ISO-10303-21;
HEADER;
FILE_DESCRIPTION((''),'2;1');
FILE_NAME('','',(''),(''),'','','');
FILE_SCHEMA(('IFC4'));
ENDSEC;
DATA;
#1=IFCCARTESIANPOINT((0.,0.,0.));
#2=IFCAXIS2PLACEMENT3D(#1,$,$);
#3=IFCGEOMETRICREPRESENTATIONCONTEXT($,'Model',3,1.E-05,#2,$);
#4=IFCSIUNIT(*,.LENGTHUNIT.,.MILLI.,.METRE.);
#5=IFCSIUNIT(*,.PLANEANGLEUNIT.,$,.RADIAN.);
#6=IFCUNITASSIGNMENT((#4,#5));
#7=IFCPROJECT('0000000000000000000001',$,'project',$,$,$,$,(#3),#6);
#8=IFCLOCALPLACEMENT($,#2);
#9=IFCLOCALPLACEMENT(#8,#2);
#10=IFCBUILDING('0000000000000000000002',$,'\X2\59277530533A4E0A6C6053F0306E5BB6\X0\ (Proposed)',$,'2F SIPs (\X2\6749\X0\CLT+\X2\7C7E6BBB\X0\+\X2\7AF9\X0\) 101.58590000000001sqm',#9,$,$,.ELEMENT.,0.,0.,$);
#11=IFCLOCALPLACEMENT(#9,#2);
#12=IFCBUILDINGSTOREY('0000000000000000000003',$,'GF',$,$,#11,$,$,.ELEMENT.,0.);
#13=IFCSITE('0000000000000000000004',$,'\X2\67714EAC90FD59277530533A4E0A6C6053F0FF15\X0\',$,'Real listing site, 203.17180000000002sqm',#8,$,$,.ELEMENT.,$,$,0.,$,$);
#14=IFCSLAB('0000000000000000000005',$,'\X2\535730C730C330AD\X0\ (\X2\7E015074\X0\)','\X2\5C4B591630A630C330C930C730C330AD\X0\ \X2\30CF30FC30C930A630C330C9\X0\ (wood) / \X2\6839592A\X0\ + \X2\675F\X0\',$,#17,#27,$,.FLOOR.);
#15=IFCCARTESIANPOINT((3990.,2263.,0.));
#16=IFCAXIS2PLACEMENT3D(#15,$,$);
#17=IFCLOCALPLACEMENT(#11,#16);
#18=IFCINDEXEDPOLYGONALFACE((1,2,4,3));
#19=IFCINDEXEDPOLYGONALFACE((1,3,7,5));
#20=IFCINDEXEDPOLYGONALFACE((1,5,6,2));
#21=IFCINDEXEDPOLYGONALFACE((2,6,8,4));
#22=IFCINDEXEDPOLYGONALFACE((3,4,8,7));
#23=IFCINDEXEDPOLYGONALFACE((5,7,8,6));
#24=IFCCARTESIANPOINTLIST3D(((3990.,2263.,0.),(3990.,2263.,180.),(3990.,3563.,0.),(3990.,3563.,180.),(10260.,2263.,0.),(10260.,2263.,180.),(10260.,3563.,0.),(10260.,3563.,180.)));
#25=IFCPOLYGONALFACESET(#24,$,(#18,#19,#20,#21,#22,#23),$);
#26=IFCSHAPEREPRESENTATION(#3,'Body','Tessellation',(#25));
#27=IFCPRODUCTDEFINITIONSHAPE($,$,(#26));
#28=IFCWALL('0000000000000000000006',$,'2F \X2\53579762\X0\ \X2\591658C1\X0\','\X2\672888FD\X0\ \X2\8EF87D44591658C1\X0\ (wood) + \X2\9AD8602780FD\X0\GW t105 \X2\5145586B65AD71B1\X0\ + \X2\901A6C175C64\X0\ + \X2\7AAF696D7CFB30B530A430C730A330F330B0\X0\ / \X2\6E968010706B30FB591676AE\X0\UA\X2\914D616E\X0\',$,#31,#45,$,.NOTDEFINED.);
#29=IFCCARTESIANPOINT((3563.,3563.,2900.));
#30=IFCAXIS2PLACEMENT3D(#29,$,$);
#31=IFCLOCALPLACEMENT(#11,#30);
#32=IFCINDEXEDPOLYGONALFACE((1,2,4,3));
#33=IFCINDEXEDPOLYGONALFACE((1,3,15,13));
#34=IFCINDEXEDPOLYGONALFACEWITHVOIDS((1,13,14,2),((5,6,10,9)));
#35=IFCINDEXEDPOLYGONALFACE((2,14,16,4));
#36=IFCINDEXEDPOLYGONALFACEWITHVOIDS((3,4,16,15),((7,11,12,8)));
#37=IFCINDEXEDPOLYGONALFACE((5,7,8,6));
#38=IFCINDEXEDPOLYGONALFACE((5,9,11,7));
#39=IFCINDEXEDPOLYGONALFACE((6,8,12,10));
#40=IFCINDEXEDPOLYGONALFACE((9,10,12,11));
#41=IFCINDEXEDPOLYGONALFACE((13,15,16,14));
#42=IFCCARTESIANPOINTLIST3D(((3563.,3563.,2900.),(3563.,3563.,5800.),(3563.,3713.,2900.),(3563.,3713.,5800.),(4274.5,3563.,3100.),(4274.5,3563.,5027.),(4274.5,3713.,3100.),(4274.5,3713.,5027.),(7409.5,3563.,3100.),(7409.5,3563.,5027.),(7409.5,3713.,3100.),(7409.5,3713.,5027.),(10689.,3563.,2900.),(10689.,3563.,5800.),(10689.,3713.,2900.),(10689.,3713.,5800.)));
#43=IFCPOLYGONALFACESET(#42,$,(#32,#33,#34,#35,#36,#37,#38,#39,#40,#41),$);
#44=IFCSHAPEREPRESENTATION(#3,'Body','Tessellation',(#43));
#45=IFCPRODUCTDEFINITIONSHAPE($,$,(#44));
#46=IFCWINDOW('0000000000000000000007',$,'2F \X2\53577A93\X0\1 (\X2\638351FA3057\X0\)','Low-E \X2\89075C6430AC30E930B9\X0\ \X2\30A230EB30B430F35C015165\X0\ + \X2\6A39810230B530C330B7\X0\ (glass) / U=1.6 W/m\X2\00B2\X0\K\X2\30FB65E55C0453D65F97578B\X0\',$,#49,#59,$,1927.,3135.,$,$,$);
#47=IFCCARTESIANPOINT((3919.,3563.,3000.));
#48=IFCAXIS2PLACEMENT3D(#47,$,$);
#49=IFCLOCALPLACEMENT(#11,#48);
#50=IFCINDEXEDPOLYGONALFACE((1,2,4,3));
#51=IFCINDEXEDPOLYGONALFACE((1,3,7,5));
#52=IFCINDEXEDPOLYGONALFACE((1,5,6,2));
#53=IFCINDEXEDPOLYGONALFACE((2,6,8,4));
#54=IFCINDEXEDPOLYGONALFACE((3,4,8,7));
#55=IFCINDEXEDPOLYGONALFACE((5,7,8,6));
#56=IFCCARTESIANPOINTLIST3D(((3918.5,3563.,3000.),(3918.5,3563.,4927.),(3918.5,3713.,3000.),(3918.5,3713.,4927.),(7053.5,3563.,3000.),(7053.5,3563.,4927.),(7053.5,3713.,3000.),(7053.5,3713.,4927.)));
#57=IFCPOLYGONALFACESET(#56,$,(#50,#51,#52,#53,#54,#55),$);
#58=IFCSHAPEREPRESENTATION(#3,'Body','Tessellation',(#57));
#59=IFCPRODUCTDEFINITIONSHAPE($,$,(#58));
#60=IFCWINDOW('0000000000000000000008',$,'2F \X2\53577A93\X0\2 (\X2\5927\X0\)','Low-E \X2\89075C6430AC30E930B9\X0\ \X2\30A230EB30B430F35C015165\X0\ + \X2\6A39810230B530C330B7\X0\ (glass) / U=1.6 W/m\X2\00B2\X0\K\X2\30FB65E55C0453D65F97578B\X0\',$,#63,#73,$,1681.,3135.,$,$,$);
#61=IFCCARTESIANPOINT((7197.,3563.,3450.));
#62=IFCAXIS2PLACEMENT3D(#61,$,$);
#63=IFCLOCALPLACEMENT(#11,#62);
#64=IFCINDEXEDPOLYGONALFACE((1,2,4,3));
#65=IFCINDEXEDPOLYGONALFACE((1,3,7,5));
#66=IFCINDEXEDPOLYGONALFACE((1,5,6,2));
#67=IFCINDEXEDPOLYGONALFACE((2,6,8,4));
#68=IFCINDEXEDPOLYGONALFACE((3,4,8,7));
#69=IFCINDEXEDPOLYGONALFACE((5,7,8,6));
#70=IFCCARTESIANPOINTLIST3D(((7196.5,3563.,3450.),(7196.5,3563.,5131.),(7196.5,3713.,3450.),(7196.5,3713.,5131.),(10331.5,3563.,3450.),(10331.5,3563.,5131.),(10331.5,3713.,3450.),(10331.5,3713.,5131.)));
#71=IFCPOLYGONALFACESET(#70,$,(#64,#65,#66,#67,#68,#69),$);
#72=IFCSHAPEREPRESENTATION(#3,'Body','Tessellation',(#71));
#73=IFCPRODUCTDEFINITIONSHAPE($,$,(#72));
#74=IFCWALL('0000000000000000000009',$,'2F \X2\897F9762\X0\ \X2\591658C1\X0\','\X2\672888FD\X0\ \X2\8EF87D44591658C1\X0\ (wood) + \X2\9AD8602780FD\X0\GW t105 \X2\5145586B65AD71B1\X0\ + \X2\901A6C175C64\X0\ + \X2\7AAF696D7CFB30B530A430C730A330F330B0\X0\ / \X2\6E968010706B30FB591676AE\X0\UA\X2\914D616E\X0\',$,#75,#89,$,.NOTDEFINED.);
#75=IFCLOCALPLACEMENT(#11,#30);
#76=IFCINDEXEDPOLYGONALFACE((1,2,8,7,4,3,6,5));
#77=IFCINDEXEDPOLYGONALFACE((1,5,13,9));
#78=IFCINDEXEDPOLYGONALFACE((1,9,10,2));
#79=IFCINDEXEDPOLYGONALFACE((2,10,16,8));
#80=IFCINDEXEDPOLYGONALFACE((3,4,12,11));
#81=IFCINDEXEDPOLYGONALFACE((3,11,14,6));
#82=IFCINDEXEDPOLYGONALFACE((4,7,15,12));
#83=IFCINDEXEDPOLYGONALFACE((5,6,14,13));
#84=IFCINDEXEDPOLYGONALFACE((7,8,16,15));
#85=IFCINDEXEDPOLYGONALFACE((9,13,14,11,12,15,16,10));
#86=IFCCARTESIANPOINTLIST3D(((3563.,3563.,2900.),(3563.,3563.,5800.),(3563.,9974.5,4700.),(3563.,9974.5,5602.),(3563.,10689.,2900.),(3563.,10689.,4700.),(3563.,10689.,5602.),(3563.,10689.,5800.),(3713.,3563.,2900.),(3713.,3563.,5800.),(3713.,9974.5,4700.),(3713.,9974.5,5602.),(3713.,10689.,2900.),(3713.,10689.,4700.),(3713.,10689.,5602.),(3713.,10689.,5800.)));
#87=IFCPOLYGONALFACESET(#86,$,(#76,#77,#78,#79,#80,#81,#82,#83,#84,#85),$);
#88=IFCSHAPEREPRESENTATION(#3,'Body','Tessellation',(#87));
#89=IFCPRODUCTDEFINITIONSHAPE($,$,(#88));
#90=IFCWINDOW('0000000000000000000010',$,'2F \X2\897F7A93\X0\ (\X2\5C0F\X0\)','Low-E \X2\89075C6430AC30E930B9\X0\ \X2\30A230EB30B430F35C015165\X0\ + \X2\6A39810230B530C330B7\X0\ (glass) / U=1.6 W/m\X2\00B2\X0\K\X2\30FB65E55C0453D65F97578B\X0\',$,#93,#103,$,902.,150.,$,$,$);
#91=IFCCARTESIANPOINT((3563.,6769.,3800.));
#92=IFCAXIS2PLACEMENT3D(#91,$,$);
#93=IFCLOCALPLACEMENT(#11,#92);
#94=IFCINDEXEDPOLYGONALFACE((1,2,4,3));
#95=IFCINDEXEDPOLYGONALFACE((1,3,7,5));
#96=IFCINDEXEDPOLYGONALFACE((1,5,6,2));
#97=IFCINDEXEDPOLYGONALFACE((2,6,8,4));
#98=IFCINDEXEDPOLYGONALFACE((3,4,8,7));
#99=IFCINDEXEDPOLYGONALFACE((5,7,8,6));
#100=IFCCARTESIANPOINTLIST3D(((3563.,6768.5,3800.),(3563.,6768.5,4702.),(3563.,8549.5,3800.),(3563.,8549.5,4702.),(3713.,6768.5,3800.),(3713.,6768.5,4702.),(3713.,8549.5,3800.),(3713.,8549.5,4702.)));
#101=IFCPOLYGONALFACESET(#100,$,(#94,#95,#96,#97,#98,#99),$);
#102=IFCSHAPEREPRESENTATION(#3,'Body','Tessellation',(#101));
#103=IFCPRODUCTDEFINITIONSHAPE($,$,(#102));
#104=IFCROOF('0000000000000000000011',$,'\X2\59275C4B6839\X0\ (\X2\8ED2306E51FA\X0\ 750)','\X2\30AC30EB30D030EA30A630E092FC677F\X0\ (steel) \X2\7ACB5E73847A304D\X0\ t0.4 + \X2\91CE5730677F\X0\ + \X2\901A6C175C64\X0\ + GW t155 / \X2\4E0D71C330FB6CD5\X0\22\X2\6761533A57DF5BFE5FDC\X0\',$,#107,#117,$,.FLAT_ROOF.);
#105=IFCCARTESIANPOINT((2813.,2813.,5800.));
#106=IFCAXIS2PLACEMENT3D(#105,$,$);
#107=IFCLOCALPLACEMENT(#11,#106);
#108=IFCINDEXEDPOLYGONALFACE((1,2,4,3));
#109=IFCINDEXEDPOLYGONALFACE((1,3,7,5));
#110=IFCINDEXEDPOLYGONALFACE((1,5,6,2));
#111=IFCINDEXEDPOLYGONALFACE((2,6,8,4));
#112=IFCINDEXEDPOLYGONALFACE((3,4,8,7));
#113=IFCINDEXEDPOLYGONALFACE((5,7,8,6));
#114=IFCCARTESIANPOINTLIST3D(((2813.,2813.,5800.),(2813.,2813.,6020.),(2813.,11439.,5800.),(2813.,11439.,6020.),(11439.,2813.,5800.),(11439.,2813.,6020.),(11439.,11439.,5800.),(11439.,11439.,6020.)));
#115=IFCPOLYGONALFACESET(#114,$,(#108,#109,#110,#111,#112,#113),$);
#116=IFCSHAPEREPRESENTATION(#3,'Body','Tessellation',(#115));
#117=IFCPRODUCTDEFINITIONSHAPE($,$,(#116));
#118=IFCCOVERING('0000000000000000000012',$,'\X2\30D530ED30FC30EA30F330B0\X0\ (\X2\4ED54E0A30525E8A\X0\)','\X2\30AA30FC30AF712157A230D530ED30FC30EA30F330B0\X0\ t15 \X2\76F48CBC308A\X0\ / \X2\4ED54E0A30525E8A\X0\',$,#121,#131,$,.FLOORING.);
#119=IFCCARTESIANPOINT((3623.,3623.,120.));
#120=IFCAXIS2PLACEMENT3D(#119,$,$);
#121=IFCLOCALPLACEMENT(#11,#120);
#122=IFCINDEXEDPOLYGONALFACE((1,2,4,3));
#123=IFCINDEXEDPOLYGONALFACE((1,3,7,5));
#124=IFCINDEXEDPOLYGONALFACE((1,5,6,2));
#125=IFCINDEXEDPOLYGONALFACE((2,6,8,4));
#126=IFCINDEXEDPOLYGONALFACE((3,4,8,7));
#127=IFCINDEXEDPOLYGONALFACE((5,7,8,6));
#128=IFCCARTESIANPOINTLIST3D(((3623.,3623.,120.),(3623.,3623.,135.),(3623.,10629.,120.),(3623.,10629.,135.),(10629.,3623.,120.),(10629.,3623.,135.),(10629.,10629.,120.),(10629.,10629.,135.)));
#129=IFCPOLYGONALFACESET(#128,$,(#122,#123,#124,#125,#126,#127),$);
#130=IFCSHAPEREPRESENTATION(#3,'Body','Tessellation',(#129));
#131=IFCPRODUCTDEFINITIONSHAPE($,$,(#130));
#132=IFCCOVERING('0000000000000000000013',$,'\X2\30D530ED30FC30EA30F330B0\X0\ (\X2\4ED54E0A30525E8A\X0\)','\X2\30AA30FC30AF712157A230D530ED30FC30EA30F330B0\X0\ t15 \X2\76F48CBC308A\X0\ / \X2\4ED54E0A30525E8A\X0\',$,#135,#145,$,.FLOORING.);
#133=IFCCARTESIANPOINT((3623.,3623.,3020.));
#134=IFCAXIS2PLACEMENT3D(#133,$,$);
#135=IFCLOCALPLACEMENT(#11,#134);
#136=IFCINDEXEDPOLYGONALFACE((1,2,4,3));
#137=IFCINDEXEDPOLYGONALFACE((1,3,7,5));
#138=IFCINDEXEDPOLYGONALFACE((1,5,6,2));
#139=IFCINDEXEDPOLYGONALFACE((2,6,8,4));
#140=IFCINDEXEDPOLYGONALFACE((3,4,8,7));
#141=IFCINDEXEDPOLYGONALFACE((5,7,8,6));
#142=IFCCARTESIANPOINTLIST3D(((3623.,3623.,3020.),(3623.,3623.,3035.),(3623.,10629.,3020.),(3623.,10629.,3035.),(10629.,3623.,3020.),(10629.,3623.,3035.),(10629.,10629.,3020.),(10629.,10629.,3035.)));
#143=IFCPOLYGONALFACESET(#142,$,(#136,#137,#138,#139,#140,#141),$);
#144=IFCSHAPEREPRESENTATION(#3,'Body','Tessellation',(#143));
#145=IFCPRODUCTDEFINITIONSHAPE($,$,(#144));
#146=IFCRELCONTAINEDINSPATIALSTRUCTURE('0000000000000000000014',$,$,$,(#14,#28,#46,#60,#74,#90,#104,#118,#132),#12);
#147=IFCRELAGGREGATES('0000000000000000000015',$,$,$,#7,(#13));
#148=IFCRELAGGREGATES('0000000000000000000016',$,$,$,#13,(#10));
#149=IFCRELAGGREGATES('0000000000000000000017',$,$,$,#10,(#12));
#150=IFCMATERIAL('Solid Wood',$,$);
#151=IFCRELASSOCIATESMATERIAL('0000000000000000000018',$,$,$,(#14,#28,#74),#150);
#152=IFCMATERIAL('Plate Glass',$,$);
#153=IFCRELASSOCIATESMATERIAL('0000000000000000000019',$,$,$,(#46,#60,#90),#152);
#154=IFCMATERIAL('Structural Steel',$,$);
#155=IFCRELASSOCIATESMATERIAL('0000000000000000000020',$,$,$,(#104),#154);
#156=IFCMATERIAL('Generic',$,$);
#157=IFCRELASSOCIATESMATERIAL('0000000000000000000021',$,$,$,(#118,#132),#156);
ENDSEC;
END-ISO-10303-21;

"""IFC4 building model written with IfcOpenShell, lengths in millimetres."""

from ifc_helpers import new_model, si_unit, frame, frame_2d, origin, place, context, project, spatial, rectangle, extrude, material, element, fill, save


model = new_model("IFC4")

# Units and contexts
model_context = context("Model", 3, precision=1e-05, world=origin())
ifc_project = project(units=[si_unit("LENGTHUNIT", "METRE", prefix="MILLI"), si_unit("PLANEANGLEUNIT", "RADIAN")], contexts=[model_context])

# Site, building, storey
site_placement = place(None, origin())
site = spatial("IfcSite", under=ifc_project, at=site_placement, Name="東京都大田区上池台５", ObjectType="Real listing site, 203.17180000000002sqm", CompositionType="ELEMENT", RefElevation=0.0)
building_placement = place(site_placement, origin())
building = spatial("IfcBuilding", under=site, at=building_placement, Name="大田区上池台の家 (Proposed)", ObjectType="2F SIPs (杉CLT+籾殻+竹) 101.58590000000001sqm", CompositionType="ELEMENT", ElevationOfRefHeight=0.0, ElevationOfTerrain=0.0)
storey_placement = place(building_placement, origin())
storey = spatial("IfcBuildingStorey", under=building, at=storey_placement, Name="GF", CompositionType="ELEMENT", Elevation=0.0)

# Slab
ifc_material_1 = material(Name="Solid Wood")
slab_1_placement = place(storey_placement, frame((3990.0, 2263.0, 0.0)))
element("IfcSlab", 1, at=slab_1_placement, inside=storey, material=ifc_material_1, Name="南デッキ (縁側)", Description="屋外ウッドデッキ ハードウッド (wood) / 根太 + 束", PredefinedType="FLOOR", context=model_context, shape_type="SweptSolid", body=[
    extrude(rectangle(XDim=6270.0, YDim=1300.0, at=frame_2d((3135.0, 650.0))), frame((3990.0, 2263.0, 0.0)), (0.0, 0.0, 1.0), 180.0),
])

# Shared definitions
ifc_material_2 = material(Name="Plate Glass")

# Wall, openings, windows
wall_1_placement = place(storey_placement, frame((3563.0, 3563.0, 2900.0)))
wall_1 = element("IfcWall", 2, at=wall_1_placement, inside=storey, material=ifc_material_1, Name="2F 南面 外壁", Description="木製 軸組外壁 (wood) + 高性能GW t105 充填断熱 + 通気層 + 窯業系サイディング / 準耐火・外皮UA配慮", PredefinedType="NOTDEFINED", context=model_context, shape_type="SweptSolid", body=[
    extrude(rectangle(XDim=7126.0, YDim=150.0, at=frame_2d((3563.0, 75.0))), frame((3563.0, 3563.0, 2900.0)), (0.0, 0.0, 1.0), 2900.0),
])
opening_1_placement = place(storey_placement, frame((3919.0, 3563.0, 3000.0)))
opening_1 = element("IfcOpeningElement", 3, at=opening_1_placement, cuts=wall_1, PredefinedType="NOTDEFINED", context=model_context, shape_type="SweptSolid", body=[
    extrude(rectangle(XDim=3135.0, YDim=150.0, at=frame_2d((1567.0, 75.0))), frame((3919.0, 3563.0, 3000.0)), (0.0, 0.0, 1.0), 1927.0),
])
opening_2_placement = place(storey_placement, frame((7197.0, 3563.0, 3450.0)))
opening_2 = element("IfcOpeningElement", 4, at=opening_2_placement, cuts=wall_1, PredefinedType="NOTDEFINED", context=model_context, shape_type="SweptSolid", body=[
    extrude(rectangle(XDim=3135.0, YDim=150.0, at=frame_2d((1567.0, 75.0))), frame((7197.0, 3563.0, 3450.0)), (0.0, 0.0, 1.0), 1681.0),
])
window_1_placement = place(storey_placement, frame((3919.0, 3563.0, 3000.0)))
window_1 = element("IfcWindow", 5, at=window_1_placement, inside=storey, material=ifc_material_2, Name="2F 南窓1 (掃出し)", Description="Low-E 複層ガラス アルゴン封入 + 樹脂サッシ (glass) / U=1.6 W/m²K・日射取得型", OverallHeight=1927.0, OverallWidth=3135.0, context=model_context, shape_type="SweptSolid", body=[
    extrude(rectangle(XDim=3135.0, YDim=150.0, at=frame_2d((1567.0, 75.0))), frame((3919.0, 3563.0, 3000.0)), (0.0, 0.0, 1.0), 1927.0),
])
fill(opening_1, window_1)
window_2_placement = place(storey_placement, frame((7197.0, 3563.0, 3450.0)))
window_2 = element("IfcWindow", 6, at=window_2_placement, inside=storey, material=ifc_material_2, Name="2F 南窓2 (大)", Description="Low-E 複層ガラス アルゴン封入 + 樹脂サッシ (glass) / U=1.6 W/m²K・日射取得型", OverallHeight=1681.0, OverallWidth=3135.0, context=model_context, shape_type="SweptSolid", body=[
    extrude(rectangle(XDim=3135.0, YDim=150.0, at=frame_2d((1567.0, 75.0))), frame((7197.0, 3563.0, 3450.0)), (0.0, 0.0, 1.0), 1681.0),
])
fill(opening_2, window_2)

# Wall, opening, window
wall_2_placement = place(storey_placement, frame((3563.0, 3563.0, 2900.0)))
wall_2 = element("IfcWall", 7, at=wall_2_placement, inside=storey, material=ifc_material_1, Name="2F 西面 外壁", Description="木製 軸組外壁 (wood) + 高性能GW t105 充填断熱 + 通気層 + 窯業系サイディング / 準耐火・外皮UA配慮", PredefinedType="NOTDEFINED", context=model_context, shape_type="SweptSolid", body=[
    extrude(rectangle(XDim=150.0, YDim=7126.0, at=frame_2d((75.0, 3563.0))), frame((3563.0, 3563.0, 2900.0)), (0.0, 0.0, 1.0), 2900.0),
])
opening_3_placement = place(storey_placement, frame((3563.0, 6769.0, 3800.0)))
opening_3 = element("IfcOpeningElement", 8, at=opening_3_placement, cuts=wall_2, PredefinedType="NOTDEFINED", context=model_context, shape_type="SweptSolid", body=[
    extrude(rectangle(XDim=150.0, YDim=1781.0, at=frame_2d((75.0, 890.0))), frame((3563.0, 6769.0, 3800.0)), (0.0, 0.0, 1.0), 902.0),
])
window_3_placement = place(storey_placement, frame((3563.0, 6769.0, 3800.0)))
window_3 = element("IfcWindow", 9, at=window_3_placement, inside=storey, material=ifc_material_2, Name="2F 西窓 (小)", Description="Low-E 複層ガラス アルゴン封入 + 樹脂サッシ (glass) / U=1.6 W/m²K・日射取得型", OverallHeight=902.0, OverallWidth=150.0, context=model_context, shape_type="SweptSolid", body=[
    extrude(rectangle(XDim=150.0, YDim=1781.0, at=frame_2d((75.0, 890.0))), frame((3563.0, 6769.0, 3800.0)), (0.0, 0.0, 1.0), 902.0),
])
fill(opening_3, window_3)

# Roof
ifc_material_3 = material(Name="Structural Steel")
roof_placement = place(storey_placement, frame((2813.0, 2813.0, 5800.0)))
element("IfcRoof", 10, at=roof_placement, inside=storey, material=ifc_material_3, Name="大屋根 (軒の出 750)", Description="ガルバリウム鋼板 (steel) 立平葺き t0.4 + 野地板 + 通気層 + GW t155 / 不燃・法22条区域対応", PredefinedType="FLAT_ROOF", context=model_context, shape_type="SweptSolid", body=[
    extrude(rectangle(XDim=8626.0, YDim=8626.0, at=frame_2d((4313.0, 4313.0))), frame((2813.0, 2813.0, 5800.0)), (0.0, 0.0, 1.0), 220.0),
])

# Coverings
ifc_material_4 = material(Name="Generic")
covering_1_placement = place(storey_placement, frame((3623.0, 3623.0, 120.0)))
element("IfcCovering", 11, at=covering_1_placement, inside=storey, material=ifc_material_4, Name="フローリング (仕上げ床)", Description="オーク無垢フローリング t15 直貼り / 仕上げ床", PredefinedType="FLOORING", context=model_context, shape_type="SweptSolid", body=[
    extrude(rectangle(XDim=7006.0, YDim=7006.0, at=frame_2d((3503.0, 3503.0))), frame((3623.0, 3623.0, 120.0)), (0.0, 0.0, 1.0), 15.0),
])
covering_2_placement = place(storey_placement, frame((3623.0, 3623.0, 3020.0)))
element("IfcCovering", 12, at=covering_2_placement, inside=storey, material=ifc_material_4, Name="フローリング (仕上げ床)", Description="オーク無垢フローリング t15 直貼り / 仕上げ床", PredefinedType="FLOORING", context=model_context, shape_type="SweptSolid", body=[
    extrude(rectangle(XDim=7006.0, YDim=7006.0, at=frame_2d((3503.0, 3503.0))), frame((3623.0, 3623.0, 3020.0)), (0.0, 0.0, 1.0), 15.0),
])

save(model, "model.ifc")
